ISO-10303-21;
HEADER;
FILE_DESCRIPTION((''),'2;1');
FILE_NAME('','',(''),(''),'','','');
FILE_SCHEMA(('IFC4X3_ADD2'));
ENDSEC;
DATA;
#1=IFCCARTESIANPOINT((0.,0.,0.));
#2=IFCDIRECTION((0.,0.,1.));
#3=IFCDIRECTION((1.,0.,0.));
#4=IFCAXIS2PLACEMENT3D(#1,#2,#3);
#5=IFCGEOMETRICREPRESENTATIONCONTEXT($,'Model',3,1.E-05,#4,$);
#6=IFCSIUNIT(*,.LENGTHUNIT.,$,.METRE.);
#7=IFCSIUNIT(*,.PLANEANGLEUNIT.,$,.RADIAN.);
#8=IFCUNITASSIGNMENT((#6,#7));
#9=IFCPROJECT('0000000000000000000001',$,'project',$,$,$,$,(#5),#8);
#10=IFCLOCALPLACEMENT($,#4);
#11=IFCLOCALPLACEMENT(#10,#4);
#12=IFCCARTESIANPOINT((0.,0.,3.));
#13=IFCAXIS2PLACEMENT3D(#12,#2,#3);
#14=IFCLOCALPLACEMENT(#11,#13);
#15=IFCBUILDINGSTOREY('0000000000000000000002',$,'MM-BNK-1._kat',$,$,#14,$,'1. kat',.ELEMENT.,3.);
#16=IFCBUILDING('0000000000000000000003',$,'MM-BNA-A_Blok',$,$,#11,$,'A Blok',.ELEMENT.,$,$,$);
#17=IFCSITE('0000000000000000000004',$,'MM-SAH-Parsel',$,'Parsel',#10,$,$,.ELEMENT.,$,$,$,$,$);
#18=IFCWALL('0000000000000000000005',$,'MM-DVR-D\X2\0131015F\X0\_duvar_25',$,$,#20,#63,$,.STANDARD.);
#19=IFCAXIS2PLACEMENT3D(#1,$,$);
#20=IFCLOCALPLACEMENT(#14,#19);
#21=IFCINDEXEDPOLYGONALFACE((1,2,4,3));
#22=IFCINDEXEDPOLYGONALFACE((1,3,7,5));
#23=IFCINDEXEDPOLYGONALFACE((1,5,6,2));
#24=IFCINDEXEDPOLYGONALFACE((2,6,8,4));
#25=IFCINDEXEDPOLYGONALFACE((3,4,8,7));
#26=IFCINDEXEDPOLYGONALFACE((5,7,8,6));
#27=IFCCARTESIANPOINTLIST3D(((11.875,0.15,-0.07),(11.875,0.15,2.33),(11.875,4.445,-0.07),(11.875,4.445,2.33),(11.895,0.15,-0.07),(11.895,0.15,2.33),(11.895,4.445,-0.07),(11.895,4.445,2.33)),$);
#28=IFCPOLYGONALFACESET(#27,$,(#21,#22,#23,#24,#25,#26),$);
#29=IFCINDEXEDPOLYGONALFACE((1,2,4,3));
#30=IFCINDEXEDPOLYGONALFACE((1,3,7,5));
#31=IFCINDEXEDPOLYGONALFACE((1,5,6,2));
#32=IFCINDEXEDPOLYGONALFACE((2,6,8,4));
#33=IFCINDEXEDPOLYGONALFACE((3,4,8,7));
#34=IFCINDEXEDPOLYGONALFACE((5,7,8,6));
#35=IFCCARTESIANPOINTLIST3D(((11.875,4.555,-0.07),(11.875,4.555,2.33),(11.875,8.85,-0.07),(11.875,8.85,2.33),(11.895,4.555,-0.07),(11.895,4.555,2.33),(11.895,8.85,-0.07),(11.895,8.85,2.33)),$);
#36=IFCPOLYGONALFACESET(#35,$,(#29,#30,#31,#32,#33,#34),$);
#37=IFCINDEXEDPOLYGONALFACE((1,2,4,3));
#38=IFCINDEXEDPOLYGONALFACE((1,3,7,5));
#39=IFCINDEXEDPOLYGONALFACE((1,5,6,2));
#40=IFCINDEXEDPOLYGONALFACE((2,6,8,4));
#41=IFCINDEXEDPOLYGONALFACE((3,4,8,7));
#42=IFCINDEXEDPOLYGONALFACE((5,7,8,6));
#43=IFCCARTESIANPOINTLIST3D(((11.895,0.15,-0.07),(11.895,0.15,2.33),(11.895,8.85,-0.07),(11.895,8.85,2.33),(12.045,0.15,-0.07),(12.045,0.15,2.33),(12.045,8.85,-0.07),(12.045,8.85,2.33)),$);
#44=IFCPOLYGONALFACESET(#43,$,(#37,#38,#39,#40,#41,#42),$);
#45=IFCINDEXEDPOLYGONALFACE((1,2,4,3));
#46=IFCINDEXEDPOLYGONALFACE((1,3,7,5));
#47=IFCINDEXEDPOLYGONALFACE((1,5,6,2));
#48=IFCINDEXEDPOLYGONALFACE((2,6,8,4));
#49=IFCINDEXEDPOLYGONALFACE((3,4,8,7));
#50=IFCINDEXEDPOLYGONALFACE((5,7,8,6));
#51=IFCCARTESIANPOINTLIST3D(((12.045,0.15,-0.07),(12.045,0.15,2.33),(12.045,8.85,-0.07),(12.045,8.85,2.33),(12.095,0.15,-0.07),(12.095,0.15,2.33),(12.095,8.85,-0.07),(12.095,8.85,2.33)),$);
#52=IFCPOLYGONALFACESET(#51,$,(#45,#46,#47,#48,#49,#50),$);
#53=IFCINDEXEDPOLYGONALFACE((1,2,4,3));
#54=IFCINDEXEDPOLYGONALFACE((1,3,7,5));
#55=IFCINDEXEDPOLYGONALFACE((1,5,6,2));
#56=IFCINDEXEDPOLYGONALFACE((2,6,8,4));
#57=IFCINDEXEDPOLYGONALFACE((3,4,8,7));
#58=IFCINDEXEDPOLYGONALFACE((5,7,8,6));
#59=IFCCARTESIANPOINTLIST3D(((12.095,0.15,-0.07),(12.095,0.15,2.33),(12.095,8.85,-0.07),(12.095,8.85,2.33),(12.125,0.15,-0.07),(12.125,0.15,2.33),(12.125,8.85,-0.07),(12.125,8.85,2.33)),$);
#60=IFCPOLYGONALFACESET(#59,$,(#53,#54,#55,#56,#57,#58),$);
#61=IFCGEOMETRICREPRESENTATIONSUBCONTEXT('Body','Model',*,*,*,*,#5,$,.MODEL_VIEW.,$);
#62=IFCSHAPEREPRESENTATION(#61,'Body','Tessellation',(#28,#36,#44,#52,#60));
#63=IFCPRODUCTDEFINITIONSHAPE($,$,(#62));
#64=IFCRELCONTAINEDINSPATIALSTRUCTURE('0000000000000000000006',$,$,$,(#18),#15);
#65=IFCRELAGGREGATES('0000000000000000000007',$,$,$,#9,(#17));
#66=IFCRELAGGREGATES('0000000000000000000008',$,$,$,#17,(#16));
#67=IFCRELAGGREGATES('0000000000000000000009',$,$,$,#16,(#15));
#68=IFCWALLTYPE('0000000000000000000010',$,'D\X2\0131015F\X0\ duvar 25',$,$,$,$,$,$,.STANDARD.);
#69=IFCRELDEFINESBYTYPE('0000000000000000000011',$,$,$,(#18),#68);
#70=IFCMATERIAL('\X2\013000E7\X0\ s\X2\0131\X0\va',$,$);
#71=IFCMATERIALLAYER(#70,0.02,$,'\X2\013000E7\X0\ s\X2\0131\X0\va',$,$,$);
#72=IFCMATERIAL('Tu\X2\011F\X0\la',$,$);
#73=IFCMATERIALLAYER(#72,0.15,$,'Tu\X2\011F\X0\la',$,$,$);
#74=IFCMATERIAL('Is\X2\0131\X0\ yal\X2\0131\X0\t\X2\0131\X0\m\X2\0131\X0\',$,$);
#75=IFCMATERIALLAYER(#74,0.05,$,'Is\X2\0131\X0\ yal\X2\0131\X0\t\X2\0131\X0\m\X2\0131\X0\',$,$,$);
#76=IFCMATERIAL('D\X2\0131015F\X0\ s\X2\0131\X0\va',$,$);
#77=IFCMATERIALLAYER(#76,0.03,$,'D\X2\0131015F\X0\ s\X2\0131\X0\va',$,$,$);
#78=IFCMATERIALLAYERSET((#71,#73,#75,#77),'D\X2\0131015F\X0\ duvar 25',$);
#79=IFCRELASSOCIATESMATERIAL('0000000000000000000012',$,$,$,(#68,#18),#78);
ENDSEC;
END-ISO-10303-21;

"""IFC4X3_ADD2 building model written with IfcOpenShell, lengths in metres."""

from ifc_helpers import new_model, si_unit, frame, origin_with_axes, place, context, subcontext, project, spatial, polyline, outline, extrude, material, layer, layer_set, type_object, element, save


model = new_model("IFC4X3_ADD2")

# Units and contexts
model_context = context("Model", 3, precision=1e-05, world=origin_with_axes())
body_context = subcontext(model_context, "Body", "Model", "MODEL_VIEW")
ifc_project = project(units=[si_unit("LENGTHUNIT", "METRE"), si_unit("PLANEANGLEUNIT", "RADIAN")], contexts=[model_context])

# Site, building, storey
site_placement = place(None, origin_with_axes())
site = spatial("IfcSite", under=ifc_project, at=site_placement, Name="MM-SAH-Parsel", ObjectType="Parsel", CompositionType="ELEMENT")
building_placement = place(site_placement, origin_with_axes())
building = spatial("IfcBuilding", under=site, at=building_placement, Name="MM-BNA-A_Blok", LongName="A Blok", CompositionType="ELEMENT")
storey_placement = place(building_placement, frame((0.0, 0.0, 3.0), z_axis=(0.0, 0.0, 1.0), x_axis=(1.0, 0.0, 0.0)))
storey = spatial("IfcBuildingStorey", under=building, at=storey_placement, Name="MM-BNK-1._kat", LongName="1. kat", CompositionType="ELEMENT", Elevation=3.0)

# Shared definitions
ifc_material_1 = material(Name="İç sıva")
ifc_layer_1 = layer(ifc_material_1, 0.02, Name="İç sıva")
ifc_material_2 = material(Name="Tuğla")
ifc_layer_2 = layer(ifc_material_2, 0.15, Name="Tuğla")
ifc_material_3 = material(Name="Isı yalıtımı")
ifc_layer_3 = layer(ifc_material_3, 0.05, Name="Isı yalıtımı")
ifc_material_4 = material(Name="Dış sıva")
ifc_layer_4 = layer(ifc_material_4, 0.03, Name="Dış sıva")
ifc_layer_set_1 = layer_set([ifc_layer_1, ifc_layer_2, ifc_layer_3, ifc_layer_4], Name="Dış duvar 25")
wall_type_1 = type_object("IfcWallType", Name="Dış duvar 25", PredefinedType="STANDARD", material=ifc_layer_set_1)

# Wall
wall_1_placement = place(storey_placement, origin_with_axes())
element("IfcWall", 1, at=wall_1_placement, inside=storey, type_object=wall_type_1, material=ifc_layer_set_1, Name="MM-DVR-Dış_duvar_25", PredefinedType="STANDARD", context=body_context, shape_type="SweptSolid", body=[
    extrude(outline(polyline([(11.895, 0.15), (11.895, 4.445), (11.875, 4.445), (11.875, 0.15), (11.895, 0.15)])), frame((0.0, 0.0, -0.07)), (0.0, 0.0, 1.0), 2.4),
    extrude(outline(polyline([(11.895, 4.555), (11.895, 8.85), (11.875, 8.85), (11.875, 4.555), (11.895, 4.555)])), frame((0.0, 0.0, -0.07)), (0.0, 0.0, 1.0), 2.4),
    extrude(outline(polyline([(12.045, 0.15), (12.045, 8.85), (11.895, 8.85), (11.895, 0.15), (12.045, 0.15)])), frame((0.0, 0.0, -0.07)), (0.0, 0.0, 1.0), 2.4),
    extrude(outline(polyline([(12.095, 0.15), (12.095, 8.85), (12.045, 8.85), (12.045, 0.15), (12.095, 0.15)])), frame((0.0, 0.0, -0.07)), (0.0, 0.0, 1.0), 2.4),
    extrude(outline(polyline([(12.125, 0.15), (12.125, 8.85), (12.095, 8.85), (12.095, 0.15), (12.125, 0.15)])), frame((0.0, 0.0, -0.07)), (0.0, 0.0, 1.0), 2.4),
])

save(model, "model.ifc")
